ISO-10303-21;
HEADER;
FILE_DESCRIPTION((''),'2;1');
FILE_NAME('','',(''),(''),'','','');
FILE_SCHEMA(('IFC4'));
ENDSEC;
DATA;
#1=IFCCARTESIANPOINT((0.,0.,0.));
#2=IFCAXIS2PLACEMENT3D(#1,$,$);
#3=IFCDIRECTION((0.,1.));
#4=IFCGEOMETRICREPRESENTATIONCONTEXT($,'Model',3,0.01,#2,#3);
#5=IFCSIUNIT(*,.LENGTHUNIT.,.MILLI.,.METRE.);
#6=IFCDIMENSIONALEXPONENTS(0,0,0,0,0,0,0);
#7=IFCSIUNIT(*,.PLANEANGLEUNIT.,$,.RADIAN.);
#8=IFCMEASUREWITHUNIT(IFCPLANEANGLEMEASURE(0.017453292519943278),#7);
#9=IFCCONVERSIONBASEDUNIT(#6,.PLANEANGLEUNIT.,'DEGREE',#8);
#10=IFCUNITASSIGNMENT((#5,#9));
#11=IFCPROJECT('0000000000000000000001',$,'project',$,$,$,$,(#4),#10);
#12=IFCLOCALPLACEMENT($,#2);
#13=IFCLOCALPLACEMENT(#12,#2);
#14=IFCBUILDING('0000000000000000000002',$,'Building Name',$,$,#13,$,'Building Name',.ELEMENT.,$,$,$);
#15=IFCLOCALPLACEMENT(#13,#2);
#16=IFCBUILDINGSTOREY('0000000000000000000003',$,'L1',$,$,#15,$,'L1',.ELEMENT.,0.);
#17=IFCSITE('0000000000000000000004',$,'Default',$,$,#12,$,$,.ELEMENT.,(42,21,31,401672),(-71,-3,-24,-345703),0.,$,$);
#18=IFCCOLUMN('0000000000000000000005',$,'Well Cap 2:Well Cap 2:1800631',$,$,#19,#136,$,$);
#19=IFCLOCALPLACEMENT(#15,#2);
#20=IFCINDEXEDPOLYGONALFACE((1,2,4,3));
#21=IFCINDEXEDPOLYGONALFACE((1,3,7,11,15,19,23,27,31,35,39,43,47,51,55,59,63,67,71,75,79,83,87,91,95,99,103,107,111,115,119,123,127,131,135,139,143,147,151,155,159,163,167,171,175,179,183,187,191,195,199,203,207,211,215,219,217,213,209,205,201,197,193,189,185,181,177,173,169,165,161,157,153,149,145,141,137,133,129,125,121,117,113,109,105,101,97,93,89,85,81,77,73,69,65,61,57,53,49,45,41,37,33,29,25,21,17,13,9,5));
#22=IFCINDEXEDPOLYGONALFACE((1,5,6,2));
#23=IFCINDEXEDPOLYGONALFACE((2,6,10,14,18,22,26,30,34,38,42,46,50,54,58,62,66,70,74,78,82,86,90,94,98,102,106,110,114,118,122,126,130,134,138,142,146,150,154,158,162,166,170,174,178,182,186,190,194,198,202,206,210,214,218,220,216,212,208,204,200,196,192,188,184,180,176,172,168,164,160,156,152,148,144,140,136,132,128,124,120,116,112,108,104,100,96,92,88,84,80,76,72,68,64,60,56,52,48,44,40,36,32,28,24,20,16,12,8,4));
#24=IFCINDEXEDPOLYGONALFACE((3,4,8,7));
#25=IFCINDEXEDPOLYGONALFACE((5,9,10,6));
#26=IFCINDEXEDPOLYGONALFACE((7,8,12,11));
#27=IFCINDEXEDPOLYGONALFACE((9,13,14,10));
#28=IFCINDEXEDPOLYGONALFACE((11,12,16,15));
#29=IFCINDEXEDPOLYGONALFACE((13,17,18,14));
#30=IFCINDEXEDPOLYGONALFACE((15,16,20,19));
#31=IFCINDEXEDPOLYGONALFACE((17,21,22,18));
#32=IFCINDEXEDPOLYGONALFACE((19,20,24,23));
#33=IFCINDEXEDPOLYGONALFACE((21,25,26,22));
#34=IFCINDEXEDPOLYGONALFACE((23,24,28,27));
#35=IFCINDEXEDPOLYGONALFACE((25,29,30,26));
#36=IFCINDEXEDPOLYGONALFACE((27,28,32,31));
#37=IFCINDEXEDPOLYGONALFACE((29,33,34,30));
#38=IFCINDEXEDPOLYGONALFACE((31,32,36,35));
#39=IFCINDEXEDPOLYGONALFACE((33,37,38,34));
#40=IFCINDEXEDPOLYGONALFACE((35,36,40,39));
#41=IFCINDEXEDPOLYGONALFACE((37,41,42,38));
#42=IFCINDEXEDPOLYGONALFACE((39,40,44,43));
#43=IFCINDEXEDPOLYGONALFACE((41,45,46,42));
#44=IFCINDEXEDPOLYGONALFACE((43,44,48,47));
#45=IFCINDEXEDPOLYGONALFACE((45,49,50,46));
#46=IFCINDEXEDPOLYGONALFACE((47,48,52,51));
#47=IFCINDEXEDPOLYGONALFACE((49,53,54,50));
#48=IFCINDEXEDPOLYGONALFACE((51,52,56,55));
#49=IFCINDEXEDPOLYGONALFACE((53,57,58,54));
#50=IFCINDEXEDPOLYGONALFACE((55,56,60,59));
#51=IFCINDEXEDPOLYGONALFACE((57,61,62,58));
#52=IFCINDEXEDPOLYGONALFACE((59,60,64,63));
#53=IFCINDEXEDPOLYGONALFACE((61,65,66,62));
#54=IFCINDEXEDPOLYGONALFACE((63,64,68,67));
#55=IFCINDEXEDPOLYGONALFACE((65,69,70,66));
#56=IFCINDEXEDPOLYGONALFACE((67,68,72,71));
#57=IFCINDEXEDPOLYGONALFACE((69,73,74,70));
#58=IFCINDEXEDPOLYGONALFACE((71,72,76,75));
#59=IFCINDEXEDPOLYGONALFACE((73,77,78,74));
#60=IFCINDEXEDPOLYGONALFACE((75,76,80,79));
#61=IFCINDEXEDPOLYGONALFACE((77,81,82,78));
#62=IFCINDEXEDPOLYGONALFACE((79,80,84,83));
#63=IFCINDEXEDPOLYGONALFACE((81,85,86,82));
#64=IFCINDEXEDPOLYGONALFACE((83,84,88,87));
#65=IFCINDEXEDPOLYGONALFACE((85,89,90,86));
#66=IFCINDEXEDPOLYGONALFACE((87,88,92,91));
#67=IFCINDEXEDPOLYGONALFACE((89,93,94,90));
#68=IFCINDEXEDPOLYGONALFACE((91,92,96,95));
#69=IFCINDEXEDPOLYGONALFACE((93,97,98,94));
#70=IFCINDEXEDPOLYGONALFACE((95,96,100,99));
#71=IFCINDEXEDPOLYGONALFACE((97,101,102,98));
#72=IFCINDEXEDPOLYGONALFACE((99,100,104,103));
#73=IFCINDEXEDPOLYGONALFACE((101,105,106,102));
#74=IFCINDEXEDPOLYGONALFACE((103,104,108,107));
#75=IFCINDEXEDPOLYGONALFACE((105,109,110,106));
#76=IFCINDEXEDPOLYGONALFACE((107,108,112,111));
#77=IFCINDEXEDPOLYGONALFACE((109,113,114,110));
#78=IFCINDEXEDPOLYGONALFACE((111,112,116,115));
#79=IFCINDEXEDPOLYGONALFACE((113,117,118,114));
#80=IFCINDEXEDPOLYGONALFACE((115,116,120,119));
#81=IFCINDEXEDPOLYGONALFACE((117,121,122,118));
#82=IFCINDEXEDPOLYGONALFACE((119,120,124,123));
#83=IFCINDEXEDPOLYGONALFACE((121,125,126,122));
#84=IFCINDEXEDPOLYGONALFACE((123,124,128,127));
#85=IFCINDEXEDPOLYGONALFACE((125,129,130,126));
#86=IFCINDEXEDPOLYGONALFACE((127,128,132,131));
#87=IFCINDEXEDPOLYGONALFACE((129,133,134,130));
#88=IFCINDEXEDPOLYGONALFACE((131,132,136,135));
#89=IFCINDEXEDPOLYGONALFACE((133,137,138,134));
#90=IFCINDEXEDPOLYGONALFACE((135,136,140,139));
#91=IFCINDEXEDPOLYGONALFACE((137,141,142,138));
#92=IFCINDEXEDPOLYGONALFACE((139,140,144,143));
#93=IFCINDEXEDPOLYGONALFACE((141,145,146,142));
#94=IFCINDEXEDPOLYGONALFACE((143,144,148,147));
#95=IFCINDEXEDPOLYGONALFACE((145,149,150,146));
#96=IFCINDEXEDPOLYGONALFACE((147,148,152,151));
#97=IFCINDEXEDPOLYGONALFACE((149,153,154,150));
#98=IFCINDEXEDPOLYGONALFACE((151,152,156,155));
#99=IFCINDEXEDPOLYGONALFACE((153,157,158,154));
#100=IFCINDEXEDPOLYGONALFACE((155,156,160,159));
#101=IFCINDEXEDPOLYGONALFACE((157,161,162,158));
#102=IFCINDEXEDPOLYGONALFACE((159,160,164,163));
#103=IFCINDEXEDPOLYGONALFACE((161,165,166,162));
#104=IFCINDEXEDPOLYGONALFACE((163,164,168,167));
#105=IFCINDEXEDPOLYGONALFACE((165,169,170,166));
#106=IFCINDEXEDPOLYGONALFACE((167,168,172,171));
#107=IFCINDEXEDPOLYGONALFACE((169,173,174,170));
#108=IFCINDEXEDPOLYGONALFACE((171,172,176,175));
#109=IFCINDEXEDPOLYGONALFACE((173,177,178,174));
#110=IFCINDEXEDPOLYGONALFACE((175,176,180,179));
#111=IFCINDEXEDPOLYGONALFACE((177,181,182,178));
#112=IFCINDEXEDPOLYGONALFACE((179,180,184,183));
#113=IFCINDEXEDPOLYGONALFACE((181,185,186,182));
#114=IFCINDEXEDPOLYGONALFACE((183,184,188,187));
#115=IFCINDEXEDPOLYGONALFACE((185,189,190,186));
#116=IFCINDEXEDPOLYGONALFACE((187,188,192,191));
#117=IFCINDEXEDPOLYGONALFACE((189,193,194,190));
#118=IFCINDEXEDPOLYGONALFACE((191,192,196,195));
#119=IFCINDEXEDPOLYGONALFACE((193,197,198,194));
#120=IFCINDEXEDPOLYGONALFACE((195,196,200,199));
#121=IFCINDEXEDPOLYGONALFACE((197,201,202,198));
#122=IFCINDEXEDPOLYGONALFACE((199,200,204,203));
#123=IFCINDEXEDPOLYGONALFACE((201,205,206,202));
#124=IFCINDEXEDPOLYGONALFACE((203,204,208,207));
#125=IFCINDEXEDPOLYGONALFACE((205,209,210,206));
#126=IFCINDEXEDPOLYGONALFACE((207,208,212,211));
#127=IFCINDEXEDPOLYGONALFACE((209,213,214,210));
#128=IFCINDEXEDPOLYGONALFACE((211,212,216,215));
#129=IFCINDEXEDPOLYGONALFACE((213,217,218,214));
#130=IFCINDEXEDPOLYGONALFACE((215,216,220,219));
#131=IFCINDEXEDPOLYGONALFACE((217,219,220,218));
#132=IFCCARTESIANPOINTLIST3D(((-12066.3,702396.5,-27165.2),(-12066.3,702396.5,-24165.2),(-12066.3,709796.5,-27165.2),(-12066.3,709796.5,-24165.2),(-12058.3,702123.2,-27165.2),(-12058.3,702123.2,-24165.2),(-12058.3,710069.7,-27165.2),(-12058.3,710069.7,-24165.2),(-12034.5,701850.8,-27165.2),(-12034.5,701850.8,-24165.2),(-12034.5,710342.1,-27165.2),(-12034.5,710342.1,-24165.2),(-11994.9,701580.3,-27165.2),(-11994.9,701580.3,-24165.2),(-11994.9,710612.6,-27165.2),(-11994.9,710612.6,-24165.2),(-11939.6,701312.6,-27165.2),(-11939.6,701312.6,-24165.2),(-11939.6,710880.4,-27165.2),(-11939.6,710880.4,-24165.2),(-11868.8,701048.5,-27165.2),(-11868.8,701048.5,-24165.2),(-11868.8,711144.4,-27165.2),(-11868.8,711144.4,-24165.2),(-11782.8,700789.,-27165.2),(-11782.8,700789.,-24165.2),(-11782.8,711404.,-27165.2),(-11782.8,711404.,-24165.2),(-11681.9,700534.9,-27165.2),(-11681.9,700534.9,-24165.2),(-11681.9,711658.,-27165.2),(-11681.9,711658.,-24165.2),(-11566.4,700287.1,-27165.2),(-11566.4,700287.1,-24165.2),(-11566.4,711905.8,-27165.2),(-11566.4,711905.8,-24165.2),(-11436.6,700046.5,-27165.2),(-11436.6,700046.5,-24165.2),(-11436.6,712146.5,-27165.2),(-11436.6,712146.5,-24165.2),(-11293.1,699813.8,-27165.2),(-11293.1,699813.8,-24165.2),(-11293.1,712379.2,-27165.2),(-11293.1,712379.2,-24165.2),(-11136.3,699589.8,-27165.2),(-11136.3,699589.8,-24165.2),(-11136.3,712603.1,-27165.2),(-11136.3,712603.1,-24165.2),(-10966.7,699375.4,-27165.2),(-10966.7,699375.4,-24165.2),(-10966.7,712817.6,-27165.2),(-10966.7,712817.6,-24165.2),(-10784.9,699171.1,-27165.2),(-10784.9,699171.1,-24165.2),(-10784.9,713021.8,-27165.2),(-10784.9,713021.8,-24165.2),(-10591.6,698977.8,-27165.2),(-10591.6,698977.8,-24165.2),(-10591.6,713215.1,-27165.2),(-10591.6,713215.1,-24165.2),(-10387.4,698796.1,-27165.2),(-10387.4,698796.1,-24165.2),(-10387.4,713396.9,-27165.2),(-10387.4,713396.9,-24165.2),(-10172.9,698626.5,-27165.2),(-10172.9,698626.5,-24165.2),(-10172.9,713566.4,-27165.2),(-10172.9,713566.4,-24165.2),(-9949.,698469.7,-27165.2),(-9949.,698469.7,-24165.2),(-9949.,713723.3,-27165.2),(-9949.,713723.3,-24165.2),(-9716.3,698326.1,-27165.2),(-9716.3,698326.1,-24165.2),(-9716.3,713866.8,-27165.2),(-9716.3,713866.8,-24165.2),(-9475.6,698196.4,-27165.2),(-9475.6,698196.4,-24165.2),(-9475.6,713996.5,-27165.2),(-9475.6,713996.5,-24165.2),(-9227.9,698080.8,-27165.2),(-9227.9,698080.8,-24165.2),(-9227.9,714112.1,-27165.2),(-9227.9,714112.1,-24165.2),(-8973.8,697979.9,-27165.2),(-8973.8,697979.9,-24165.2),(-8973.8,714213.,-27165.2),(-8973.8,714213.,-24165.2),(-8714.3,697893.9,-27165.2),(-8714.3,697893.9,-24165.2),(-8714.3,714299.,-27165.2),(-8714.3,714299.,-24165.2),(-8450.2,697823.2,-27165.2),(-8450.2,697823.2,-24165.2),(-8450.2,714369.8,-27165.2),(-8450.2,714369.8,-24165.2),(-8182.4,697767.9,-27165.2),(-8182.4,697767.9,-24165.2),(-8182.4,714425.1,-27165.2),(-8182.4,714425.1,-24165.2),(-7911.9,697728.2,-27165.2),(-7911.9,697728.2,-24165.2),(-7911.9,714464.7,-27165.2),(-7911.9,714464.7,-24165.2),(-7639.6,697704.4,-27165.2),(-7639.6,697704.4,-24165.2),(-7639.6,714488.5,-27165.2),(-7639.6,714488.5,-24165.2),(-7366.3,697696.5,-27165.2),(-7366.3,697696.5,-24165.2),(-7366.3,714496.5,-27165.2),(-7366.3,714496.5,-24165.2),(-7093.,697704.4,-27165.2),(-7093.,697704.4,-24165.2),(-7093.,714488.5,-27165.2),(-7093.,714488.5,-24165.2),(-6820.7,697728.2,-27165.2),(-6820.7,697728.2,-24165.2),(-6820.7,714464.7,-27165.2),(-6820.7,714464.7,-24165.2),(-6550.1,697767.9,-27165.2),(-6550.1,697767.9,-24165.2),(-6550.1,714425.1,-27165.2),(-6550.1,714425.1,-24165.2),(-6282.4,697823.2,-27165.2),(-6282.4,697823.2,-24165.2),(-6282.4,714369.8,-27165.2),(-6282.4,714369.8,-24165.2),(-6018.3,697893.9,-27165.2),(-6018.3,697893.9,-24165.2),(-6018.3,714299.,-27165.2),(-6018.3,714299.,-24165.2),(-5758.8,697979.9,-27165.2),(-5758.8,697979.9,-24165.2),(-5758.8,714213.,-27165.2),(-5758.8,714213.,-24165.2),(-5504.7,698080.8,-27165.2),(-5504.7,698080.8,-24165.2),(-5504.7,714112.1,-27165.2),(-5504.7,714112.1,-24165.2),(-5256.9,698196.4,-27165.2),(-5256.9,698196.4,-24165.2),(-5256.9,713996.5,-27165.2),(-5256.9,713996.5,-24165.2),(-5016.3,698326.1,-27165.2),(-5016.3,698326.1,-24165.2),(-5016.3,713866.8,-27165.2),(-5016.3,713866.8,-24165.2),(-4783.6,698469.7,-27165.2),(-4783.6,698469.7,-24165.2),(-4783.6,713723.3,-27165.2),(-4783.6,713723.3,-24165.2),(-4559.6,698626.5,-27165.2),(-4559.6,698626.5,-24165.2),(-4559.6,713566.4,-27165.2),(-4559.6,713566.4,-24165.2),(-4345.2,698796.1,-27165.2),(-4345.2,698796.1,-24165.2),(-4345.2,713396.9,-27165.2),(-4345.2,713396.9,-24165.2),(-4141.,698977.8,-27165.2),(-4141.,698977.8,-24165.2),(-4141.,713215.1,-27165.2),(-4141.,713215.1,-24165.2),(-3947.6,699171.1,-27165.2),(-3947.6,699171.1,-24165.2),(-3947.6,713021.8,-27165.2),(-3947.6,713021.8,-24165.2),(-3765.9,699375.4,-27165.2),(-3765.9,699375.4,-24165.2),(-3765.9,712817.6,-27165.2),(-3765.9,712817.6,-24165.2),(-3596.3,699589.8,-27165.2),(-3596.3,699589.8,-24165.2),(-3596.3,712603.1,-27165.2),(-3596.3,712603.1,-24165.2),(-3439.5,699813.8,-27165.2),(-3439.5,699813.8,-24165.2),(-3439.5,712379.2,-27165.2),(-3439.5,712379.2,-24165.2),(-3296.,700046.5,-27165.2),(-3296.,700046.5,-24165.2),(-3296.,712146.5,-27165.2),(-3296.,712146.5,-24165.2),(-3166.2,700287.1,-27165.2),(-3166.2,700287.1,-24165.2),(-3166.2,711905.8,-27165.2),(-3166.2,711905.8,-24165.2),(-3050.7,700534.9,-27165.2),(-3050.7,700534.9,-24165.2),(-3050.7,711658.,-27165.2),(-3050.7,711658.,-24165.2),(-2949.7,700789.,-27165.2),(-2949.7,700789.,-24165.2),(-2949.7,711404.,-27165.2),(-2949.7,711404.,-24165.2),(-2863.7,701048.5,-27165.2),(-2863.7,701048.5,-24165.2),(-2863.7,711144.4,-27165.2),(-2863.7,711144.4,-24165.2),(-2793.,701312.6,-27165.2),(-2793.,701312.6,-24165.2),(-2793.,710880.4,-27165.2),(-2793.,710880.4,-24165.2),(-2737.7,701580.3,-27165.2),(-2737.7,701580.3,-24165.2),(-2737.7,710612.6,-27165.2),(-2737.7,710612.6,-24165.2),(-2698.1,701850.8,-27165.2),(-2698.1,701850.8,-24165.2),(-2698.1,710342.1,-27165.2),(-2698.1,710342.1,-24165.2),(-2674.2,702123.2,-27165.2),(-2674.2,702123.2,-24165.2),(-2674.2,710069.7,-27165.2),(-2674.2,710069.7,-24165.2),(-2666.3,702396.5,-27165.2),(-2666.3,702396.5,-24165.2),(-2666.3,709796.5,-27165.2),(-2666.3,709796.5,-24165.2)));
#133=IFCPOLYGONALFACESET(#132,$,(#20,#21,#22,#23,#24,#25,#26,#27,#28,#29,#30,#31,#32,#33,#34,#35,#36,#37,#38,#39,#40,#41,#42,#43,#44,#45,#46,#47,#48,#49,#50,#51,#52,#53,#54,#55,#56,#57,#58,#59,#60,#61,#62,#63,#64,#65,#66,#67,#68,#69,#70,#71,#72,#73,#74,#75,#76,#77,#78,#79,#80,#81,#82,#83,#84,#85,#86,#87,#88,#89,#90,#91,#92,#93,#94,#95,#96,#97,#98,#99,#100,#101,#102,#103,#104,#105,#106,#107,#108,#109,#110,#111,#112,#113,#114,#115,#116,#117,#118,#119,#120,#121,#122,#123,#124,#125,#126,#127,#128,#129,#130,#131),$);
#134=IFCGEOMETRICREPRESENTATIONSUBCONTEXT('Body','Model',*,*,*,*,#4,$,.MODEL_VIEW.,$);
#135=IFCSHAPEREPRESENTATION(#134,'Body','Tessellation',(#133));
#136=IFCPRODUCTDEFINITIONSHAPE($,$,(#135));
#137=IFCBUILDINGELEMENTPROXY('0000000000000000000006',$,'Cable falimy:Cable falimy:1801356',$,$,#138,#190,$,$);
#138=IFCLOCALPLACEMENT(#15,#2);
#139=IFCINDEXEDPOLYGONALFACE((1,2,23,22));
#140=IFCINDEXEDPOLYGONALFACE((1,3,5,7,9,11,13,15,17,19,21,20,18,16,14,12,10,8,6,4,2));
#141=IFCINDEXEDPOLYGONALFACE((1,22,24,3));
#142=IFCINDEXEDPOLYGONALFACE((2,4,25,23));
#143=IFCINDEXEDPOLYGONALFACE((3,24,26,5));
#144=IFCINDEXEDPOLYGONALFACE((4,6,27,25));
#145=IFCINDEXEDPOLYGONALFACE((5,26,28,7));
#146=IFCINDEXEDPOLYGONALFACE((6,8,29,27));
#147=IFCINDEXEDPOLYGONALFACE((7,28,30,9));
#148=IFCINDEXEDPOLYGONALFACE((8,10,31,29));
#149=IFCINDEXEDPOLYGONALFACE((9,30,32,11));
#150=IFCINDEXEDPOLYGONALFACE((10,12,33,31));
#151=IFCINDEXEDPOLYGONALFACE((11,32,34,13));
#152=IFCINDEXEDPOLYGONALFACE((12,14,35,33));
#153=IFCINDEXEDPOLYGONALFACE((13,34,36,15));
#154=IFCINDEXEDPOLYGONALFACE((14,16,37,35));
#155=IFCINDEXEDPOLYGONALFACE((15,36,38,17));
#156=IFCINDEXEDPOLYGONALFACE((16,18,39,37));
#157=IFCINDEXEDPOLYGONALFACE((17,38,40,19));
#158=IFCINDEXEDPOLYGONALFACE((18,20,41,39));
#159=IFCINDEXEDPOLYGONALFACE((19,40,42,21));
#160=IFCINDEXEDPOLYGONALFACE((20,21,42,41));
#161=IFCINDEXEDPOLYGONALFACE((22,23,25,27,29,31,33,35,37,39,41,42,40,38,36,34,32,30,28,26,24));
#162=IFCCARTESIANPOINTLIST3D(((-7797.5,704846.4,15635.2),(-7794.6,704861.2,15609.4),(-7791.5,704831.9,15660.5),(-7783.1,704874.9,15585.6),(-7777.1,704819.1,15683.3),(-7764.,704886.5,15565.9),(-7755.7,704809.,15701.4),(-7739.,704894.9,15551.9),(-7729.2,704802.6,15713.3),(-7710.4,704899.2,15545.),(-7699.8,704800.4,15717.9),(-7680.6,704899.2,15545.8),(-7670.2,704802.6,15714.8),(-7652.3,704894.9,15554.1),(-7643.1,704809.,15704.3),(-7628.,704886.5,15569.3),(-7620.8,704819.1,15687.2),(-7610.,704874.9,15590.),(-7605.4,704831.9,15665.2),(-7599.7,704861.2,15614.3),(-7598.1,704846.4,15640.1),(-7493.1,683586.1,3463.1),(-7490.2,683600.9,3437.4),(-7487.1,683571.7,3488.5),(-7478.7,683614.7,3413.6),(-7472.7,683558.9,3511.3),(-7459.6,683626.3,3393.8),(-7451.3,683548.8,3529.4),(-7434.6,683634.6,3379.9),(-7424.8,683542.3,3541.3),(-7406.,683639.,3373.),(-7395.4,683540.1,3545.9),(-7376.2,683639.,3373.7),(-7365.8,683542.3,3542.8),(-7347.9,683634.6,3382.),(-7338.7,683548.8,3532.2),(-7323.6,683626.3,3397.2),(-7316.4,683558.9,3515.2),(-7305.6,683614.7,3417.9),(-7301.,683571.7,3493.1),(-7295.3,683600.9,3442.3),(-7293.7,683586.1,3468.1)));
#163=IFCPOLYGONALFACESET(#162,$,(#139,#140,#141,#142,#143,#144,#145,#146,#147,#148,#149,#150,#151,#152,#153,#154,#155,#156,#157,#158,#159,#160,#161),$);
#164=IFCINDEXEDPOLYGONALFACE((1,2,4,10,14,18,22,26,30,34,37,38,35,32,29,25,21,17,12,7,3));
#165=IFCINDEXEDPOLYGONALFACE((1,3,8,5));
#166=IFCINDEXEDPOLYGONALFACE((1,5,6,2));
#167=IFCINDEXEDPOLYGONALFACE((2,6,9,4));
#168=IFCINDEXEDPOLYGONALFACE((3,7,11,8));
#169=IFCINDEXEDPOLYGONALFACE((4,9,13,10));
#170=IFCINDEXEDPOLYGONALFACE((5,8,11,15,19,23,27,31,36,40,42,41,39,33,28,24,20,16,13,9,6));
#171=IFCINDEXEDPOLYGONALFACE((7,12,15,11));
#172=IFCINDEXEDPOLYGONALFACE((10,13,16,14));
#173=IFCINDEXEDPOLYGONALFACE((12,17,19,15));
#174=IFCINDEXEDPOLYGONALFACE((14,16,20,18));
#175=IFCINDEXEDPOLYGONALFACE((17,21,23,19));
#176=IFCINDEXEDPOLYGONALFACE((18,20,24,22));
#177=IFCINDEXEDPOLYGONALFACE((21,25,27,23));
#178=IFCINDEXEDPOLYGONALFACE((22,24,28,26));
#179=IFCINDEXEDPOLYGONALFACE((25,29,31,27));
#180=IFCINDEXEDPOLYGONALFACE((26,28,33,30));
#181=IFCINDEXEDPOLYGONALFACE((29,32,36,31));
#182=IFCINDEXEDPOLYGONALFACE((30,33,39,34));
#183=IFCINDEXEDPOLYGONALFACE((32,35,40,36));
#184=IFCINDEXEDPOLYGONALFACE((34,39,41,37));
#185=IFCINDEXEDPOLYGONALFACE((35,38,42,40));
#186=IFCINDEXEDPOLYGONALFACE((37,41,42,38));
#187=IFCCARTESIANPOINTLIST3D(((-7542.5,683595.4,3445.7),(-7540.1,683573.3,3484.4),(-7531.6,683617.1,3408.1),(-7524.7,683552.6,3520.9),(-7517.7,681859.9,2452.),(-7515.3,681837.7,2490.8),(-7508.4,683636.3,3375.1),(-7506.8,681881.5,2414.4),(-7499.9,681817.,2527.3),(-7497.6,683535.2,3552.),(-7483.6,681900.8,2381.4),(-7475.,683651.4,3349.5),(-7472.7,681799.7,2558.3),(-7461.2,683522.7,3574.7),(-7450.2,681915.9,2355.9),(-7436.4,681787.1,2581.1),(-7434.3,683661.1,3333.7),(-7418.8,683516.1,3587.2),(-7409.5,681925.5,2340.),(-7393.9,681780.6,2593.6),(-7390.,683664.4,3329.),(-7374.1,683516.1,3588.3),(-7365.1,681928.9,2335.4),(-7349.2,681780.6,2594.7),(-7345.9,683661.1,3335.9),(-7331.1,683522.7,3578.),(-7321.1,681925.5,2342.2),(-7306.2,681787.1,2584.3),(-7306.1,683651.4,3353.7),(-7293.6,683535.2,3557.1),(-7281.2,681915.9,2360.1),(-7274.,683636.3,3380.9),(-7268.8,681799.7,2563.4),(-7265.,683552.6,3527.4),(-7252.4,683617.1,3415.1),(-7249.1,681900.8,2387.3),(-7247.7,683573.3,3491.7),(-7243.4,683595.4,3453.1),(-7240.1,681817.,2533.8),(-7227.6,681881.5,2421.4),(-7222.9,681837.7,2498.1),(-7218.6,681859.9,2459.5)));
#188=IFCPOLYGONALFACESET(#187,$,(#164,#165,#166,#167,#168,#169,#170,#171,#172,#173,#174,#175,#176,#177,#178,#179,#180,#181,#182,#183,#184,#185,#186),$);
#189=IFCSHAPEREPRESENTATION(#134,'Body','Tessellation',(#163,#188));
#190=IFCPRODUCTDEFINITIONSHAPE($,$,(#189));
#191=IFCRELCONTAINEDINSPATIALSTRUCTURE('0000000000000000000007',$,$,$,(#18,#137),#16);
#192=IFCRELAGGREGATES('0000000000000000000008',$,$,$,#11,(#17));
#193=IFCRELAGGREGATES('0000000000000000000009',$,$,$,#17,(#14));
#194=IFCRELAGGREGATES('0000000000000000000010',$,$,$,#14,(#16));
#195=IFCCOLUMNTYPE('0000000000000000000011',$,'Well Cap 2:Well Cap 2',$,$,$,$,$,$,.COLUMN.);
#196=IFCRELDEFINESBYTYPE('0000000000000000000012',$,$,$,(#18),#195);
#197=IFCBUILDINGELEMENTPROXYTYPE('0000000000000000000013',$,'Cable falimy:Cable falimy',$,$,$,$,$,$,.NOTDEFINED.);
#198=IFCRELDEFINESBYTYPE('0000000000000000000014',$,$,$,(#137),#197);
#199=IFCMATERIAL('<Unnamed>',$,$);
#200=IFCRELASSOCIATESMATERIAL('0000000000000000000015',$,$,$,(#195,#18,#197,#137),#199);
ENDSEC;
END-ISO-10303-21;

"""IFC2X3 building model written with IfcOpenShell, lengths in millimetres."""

from ifc_helpers import new_model, entity, si_unit, converted_unit, direction, frame, frame_2d, origin, place, context, subcontext, project, spatial, polyline, circle_curve, parameter, trimmed, segment, composite_curve, circle, outline, extrude, source, transform, mapped, material, type_object, type_shapes, element, save


model = new_model("IFC2X3")

# Units and contexts
model_context = context("Model", 3, precision=0.01, world=origin(), true_north=direction((0.0, 1.0)))
body_context = subcontext(model_context, "Body", "Model", "MODEL_VIEW")
ifc_project = project(units=[si_unit("LENGTHUNIT", "METRE", prefix="MILLI"), converted_unit("PLANEANGLEUNIT", "DEGREE", entity("IfcPlaneAngleMeasure", 0.017453292519943278), si_unit("PLANEANGLEUNIT", "RADIAN"), dimensions=[0, 0, 0, 0, 0, 0, 0])], contexts=[model_context])

# Site, building, storey
site_placement = place(None, origin())
site = spatial("IfcSite", under=ifc_project, at=site_placement, Name="Default", CompositionType="ELEMENT", RefLatitude=(42, 21, 31, 401672), RefLongitude=(-71, -3, -24, -345703), RefElevation=0.0)
building_placement = place(site_placement, origin())
building = spatial("IfcBuilding", under=site, at=building_placement, Name="Building Name", LongName="Building Name", CompositionType="ELEMENT")
storey_placement = place(building_placement, origin())
storey = spatial("IfcBuildingStorey", under=building, at=storey_placement, Name="L1", LongName="L1", CompositionType="ELEMENT", Elevation=0.0)

# Column
ifc_material = material(Name="<Unnamed>")
column_type_1 = type_object("IfcColumnType", Name="Well Cap 2:Well Cap 2", PredefinedType="COLUMN", material=ifc_material)
shared_shape_1 = source(origin(), body_context, "Body", "SweptSolid", [
    extrude(outline(composite_curve([segment(polyline([(-3700.0, -4700.0), (3700.0, -4700.0)]), True, "CONTINUOUS"), segment(trimmed(circle_curve(frame_2d((3700.0, 0.0), x_axis=(0.0, -1.0)), 4700.0), [parameter(0.0)], [parameter(180.0)], True, "PARAMETER"), True, "CONTINUOUS"), segment(polyline([(3700.0, 4700.0), (-3700.0, 4700.0)]), True, "CONTINUOUS"), segment(trimmed(circle_curve(frame_2d((-3700.0, 0.0), x_axis=(0.0, 1.0)), 4700.0), [parameter(0.0)], [parameter(180.0)], True, "PARAMETER"), True, "CONTINUOUS")], self_intersect=False)), frame((8064.3, 0.0, 0.0), z_axis=(0.0, 0.0, 1.0), x_axis=(0.0, -1.0, 0.0)), (0.0, 0.0, 1.0), 3000.0),
])
type_shapes(column_type_1, [shared_shape_1])
column_1_placement = place(storey_placement, frame((-15430.5, 706096.5, -27165.2)))
element("IfcColumn", 1, at=column_1_placement, inside=storey, type_object=column_type_1, material=ifc_material, Name="Well Cap 2:Well Cap 2:1800631", context=body_context, shape_type="MappedRepresentation", body=[
    mapped(shared_shape_1, transform((0.0, 0.0, 0.0), scale=1.0)),
])

# Building element proxy
building_element_proxy_type_1 = type_object("IfcBuildingElementProxyType", Name="Cable falimy:Cable falimy", PredefinedType="NOTDEFINED", material=ifc_material)
shared_shape_2 = source(origin(), body_context, "Body", "SweptSolid", [
    extrude(circle(Radius=100.0, at=frame_2d((0.0, 0.0), x_axis=(1.0, 0.0))), frame((0.0, 0.0, 0.0), z_axis=(0.867765, 0.0, 0.496974), x_axis=(-0.496974, 0.0, 0.867765)), (0.0, 0.0, 1.0), 24500.0),
    extrude(circle(Radius=150.0, at=frame_2d((0.0, 0.0), x_axis=(1.0, 0.0))), frame((-1735.5, 0.0, -993.9), z_axis=(0.867765, 0.0, 0.496974), x_axis=(0.496974, 0.0, -0.867765)), (0.0, 0.0, 1.0), 2000.0),
])
type_shapes(building_element_proxy_type_1, [shared_shape_2])
proxy_1_placement = place(storey_placement, frame((-7393.2, 683589.8, 3459.1), z_axis=(-0.025001, 0.0, 0.999687), x_axis=(0.0, 1.0, 0.0)))
element("IfcBuildingElementProxy", 2, at=proxy_1_placement, inside=storey, type_object=building_element_proxy_type_1, material=ifc_material, Name="Cable falimy:Cable falimy:1801356", context=body_context, shape_type="MappedRepresentation", body=[
    mapped(shared_shape_2, transform((0.0, 0.0, 0.0), scale=1.0)),
])

save(model, "model.ifc")
